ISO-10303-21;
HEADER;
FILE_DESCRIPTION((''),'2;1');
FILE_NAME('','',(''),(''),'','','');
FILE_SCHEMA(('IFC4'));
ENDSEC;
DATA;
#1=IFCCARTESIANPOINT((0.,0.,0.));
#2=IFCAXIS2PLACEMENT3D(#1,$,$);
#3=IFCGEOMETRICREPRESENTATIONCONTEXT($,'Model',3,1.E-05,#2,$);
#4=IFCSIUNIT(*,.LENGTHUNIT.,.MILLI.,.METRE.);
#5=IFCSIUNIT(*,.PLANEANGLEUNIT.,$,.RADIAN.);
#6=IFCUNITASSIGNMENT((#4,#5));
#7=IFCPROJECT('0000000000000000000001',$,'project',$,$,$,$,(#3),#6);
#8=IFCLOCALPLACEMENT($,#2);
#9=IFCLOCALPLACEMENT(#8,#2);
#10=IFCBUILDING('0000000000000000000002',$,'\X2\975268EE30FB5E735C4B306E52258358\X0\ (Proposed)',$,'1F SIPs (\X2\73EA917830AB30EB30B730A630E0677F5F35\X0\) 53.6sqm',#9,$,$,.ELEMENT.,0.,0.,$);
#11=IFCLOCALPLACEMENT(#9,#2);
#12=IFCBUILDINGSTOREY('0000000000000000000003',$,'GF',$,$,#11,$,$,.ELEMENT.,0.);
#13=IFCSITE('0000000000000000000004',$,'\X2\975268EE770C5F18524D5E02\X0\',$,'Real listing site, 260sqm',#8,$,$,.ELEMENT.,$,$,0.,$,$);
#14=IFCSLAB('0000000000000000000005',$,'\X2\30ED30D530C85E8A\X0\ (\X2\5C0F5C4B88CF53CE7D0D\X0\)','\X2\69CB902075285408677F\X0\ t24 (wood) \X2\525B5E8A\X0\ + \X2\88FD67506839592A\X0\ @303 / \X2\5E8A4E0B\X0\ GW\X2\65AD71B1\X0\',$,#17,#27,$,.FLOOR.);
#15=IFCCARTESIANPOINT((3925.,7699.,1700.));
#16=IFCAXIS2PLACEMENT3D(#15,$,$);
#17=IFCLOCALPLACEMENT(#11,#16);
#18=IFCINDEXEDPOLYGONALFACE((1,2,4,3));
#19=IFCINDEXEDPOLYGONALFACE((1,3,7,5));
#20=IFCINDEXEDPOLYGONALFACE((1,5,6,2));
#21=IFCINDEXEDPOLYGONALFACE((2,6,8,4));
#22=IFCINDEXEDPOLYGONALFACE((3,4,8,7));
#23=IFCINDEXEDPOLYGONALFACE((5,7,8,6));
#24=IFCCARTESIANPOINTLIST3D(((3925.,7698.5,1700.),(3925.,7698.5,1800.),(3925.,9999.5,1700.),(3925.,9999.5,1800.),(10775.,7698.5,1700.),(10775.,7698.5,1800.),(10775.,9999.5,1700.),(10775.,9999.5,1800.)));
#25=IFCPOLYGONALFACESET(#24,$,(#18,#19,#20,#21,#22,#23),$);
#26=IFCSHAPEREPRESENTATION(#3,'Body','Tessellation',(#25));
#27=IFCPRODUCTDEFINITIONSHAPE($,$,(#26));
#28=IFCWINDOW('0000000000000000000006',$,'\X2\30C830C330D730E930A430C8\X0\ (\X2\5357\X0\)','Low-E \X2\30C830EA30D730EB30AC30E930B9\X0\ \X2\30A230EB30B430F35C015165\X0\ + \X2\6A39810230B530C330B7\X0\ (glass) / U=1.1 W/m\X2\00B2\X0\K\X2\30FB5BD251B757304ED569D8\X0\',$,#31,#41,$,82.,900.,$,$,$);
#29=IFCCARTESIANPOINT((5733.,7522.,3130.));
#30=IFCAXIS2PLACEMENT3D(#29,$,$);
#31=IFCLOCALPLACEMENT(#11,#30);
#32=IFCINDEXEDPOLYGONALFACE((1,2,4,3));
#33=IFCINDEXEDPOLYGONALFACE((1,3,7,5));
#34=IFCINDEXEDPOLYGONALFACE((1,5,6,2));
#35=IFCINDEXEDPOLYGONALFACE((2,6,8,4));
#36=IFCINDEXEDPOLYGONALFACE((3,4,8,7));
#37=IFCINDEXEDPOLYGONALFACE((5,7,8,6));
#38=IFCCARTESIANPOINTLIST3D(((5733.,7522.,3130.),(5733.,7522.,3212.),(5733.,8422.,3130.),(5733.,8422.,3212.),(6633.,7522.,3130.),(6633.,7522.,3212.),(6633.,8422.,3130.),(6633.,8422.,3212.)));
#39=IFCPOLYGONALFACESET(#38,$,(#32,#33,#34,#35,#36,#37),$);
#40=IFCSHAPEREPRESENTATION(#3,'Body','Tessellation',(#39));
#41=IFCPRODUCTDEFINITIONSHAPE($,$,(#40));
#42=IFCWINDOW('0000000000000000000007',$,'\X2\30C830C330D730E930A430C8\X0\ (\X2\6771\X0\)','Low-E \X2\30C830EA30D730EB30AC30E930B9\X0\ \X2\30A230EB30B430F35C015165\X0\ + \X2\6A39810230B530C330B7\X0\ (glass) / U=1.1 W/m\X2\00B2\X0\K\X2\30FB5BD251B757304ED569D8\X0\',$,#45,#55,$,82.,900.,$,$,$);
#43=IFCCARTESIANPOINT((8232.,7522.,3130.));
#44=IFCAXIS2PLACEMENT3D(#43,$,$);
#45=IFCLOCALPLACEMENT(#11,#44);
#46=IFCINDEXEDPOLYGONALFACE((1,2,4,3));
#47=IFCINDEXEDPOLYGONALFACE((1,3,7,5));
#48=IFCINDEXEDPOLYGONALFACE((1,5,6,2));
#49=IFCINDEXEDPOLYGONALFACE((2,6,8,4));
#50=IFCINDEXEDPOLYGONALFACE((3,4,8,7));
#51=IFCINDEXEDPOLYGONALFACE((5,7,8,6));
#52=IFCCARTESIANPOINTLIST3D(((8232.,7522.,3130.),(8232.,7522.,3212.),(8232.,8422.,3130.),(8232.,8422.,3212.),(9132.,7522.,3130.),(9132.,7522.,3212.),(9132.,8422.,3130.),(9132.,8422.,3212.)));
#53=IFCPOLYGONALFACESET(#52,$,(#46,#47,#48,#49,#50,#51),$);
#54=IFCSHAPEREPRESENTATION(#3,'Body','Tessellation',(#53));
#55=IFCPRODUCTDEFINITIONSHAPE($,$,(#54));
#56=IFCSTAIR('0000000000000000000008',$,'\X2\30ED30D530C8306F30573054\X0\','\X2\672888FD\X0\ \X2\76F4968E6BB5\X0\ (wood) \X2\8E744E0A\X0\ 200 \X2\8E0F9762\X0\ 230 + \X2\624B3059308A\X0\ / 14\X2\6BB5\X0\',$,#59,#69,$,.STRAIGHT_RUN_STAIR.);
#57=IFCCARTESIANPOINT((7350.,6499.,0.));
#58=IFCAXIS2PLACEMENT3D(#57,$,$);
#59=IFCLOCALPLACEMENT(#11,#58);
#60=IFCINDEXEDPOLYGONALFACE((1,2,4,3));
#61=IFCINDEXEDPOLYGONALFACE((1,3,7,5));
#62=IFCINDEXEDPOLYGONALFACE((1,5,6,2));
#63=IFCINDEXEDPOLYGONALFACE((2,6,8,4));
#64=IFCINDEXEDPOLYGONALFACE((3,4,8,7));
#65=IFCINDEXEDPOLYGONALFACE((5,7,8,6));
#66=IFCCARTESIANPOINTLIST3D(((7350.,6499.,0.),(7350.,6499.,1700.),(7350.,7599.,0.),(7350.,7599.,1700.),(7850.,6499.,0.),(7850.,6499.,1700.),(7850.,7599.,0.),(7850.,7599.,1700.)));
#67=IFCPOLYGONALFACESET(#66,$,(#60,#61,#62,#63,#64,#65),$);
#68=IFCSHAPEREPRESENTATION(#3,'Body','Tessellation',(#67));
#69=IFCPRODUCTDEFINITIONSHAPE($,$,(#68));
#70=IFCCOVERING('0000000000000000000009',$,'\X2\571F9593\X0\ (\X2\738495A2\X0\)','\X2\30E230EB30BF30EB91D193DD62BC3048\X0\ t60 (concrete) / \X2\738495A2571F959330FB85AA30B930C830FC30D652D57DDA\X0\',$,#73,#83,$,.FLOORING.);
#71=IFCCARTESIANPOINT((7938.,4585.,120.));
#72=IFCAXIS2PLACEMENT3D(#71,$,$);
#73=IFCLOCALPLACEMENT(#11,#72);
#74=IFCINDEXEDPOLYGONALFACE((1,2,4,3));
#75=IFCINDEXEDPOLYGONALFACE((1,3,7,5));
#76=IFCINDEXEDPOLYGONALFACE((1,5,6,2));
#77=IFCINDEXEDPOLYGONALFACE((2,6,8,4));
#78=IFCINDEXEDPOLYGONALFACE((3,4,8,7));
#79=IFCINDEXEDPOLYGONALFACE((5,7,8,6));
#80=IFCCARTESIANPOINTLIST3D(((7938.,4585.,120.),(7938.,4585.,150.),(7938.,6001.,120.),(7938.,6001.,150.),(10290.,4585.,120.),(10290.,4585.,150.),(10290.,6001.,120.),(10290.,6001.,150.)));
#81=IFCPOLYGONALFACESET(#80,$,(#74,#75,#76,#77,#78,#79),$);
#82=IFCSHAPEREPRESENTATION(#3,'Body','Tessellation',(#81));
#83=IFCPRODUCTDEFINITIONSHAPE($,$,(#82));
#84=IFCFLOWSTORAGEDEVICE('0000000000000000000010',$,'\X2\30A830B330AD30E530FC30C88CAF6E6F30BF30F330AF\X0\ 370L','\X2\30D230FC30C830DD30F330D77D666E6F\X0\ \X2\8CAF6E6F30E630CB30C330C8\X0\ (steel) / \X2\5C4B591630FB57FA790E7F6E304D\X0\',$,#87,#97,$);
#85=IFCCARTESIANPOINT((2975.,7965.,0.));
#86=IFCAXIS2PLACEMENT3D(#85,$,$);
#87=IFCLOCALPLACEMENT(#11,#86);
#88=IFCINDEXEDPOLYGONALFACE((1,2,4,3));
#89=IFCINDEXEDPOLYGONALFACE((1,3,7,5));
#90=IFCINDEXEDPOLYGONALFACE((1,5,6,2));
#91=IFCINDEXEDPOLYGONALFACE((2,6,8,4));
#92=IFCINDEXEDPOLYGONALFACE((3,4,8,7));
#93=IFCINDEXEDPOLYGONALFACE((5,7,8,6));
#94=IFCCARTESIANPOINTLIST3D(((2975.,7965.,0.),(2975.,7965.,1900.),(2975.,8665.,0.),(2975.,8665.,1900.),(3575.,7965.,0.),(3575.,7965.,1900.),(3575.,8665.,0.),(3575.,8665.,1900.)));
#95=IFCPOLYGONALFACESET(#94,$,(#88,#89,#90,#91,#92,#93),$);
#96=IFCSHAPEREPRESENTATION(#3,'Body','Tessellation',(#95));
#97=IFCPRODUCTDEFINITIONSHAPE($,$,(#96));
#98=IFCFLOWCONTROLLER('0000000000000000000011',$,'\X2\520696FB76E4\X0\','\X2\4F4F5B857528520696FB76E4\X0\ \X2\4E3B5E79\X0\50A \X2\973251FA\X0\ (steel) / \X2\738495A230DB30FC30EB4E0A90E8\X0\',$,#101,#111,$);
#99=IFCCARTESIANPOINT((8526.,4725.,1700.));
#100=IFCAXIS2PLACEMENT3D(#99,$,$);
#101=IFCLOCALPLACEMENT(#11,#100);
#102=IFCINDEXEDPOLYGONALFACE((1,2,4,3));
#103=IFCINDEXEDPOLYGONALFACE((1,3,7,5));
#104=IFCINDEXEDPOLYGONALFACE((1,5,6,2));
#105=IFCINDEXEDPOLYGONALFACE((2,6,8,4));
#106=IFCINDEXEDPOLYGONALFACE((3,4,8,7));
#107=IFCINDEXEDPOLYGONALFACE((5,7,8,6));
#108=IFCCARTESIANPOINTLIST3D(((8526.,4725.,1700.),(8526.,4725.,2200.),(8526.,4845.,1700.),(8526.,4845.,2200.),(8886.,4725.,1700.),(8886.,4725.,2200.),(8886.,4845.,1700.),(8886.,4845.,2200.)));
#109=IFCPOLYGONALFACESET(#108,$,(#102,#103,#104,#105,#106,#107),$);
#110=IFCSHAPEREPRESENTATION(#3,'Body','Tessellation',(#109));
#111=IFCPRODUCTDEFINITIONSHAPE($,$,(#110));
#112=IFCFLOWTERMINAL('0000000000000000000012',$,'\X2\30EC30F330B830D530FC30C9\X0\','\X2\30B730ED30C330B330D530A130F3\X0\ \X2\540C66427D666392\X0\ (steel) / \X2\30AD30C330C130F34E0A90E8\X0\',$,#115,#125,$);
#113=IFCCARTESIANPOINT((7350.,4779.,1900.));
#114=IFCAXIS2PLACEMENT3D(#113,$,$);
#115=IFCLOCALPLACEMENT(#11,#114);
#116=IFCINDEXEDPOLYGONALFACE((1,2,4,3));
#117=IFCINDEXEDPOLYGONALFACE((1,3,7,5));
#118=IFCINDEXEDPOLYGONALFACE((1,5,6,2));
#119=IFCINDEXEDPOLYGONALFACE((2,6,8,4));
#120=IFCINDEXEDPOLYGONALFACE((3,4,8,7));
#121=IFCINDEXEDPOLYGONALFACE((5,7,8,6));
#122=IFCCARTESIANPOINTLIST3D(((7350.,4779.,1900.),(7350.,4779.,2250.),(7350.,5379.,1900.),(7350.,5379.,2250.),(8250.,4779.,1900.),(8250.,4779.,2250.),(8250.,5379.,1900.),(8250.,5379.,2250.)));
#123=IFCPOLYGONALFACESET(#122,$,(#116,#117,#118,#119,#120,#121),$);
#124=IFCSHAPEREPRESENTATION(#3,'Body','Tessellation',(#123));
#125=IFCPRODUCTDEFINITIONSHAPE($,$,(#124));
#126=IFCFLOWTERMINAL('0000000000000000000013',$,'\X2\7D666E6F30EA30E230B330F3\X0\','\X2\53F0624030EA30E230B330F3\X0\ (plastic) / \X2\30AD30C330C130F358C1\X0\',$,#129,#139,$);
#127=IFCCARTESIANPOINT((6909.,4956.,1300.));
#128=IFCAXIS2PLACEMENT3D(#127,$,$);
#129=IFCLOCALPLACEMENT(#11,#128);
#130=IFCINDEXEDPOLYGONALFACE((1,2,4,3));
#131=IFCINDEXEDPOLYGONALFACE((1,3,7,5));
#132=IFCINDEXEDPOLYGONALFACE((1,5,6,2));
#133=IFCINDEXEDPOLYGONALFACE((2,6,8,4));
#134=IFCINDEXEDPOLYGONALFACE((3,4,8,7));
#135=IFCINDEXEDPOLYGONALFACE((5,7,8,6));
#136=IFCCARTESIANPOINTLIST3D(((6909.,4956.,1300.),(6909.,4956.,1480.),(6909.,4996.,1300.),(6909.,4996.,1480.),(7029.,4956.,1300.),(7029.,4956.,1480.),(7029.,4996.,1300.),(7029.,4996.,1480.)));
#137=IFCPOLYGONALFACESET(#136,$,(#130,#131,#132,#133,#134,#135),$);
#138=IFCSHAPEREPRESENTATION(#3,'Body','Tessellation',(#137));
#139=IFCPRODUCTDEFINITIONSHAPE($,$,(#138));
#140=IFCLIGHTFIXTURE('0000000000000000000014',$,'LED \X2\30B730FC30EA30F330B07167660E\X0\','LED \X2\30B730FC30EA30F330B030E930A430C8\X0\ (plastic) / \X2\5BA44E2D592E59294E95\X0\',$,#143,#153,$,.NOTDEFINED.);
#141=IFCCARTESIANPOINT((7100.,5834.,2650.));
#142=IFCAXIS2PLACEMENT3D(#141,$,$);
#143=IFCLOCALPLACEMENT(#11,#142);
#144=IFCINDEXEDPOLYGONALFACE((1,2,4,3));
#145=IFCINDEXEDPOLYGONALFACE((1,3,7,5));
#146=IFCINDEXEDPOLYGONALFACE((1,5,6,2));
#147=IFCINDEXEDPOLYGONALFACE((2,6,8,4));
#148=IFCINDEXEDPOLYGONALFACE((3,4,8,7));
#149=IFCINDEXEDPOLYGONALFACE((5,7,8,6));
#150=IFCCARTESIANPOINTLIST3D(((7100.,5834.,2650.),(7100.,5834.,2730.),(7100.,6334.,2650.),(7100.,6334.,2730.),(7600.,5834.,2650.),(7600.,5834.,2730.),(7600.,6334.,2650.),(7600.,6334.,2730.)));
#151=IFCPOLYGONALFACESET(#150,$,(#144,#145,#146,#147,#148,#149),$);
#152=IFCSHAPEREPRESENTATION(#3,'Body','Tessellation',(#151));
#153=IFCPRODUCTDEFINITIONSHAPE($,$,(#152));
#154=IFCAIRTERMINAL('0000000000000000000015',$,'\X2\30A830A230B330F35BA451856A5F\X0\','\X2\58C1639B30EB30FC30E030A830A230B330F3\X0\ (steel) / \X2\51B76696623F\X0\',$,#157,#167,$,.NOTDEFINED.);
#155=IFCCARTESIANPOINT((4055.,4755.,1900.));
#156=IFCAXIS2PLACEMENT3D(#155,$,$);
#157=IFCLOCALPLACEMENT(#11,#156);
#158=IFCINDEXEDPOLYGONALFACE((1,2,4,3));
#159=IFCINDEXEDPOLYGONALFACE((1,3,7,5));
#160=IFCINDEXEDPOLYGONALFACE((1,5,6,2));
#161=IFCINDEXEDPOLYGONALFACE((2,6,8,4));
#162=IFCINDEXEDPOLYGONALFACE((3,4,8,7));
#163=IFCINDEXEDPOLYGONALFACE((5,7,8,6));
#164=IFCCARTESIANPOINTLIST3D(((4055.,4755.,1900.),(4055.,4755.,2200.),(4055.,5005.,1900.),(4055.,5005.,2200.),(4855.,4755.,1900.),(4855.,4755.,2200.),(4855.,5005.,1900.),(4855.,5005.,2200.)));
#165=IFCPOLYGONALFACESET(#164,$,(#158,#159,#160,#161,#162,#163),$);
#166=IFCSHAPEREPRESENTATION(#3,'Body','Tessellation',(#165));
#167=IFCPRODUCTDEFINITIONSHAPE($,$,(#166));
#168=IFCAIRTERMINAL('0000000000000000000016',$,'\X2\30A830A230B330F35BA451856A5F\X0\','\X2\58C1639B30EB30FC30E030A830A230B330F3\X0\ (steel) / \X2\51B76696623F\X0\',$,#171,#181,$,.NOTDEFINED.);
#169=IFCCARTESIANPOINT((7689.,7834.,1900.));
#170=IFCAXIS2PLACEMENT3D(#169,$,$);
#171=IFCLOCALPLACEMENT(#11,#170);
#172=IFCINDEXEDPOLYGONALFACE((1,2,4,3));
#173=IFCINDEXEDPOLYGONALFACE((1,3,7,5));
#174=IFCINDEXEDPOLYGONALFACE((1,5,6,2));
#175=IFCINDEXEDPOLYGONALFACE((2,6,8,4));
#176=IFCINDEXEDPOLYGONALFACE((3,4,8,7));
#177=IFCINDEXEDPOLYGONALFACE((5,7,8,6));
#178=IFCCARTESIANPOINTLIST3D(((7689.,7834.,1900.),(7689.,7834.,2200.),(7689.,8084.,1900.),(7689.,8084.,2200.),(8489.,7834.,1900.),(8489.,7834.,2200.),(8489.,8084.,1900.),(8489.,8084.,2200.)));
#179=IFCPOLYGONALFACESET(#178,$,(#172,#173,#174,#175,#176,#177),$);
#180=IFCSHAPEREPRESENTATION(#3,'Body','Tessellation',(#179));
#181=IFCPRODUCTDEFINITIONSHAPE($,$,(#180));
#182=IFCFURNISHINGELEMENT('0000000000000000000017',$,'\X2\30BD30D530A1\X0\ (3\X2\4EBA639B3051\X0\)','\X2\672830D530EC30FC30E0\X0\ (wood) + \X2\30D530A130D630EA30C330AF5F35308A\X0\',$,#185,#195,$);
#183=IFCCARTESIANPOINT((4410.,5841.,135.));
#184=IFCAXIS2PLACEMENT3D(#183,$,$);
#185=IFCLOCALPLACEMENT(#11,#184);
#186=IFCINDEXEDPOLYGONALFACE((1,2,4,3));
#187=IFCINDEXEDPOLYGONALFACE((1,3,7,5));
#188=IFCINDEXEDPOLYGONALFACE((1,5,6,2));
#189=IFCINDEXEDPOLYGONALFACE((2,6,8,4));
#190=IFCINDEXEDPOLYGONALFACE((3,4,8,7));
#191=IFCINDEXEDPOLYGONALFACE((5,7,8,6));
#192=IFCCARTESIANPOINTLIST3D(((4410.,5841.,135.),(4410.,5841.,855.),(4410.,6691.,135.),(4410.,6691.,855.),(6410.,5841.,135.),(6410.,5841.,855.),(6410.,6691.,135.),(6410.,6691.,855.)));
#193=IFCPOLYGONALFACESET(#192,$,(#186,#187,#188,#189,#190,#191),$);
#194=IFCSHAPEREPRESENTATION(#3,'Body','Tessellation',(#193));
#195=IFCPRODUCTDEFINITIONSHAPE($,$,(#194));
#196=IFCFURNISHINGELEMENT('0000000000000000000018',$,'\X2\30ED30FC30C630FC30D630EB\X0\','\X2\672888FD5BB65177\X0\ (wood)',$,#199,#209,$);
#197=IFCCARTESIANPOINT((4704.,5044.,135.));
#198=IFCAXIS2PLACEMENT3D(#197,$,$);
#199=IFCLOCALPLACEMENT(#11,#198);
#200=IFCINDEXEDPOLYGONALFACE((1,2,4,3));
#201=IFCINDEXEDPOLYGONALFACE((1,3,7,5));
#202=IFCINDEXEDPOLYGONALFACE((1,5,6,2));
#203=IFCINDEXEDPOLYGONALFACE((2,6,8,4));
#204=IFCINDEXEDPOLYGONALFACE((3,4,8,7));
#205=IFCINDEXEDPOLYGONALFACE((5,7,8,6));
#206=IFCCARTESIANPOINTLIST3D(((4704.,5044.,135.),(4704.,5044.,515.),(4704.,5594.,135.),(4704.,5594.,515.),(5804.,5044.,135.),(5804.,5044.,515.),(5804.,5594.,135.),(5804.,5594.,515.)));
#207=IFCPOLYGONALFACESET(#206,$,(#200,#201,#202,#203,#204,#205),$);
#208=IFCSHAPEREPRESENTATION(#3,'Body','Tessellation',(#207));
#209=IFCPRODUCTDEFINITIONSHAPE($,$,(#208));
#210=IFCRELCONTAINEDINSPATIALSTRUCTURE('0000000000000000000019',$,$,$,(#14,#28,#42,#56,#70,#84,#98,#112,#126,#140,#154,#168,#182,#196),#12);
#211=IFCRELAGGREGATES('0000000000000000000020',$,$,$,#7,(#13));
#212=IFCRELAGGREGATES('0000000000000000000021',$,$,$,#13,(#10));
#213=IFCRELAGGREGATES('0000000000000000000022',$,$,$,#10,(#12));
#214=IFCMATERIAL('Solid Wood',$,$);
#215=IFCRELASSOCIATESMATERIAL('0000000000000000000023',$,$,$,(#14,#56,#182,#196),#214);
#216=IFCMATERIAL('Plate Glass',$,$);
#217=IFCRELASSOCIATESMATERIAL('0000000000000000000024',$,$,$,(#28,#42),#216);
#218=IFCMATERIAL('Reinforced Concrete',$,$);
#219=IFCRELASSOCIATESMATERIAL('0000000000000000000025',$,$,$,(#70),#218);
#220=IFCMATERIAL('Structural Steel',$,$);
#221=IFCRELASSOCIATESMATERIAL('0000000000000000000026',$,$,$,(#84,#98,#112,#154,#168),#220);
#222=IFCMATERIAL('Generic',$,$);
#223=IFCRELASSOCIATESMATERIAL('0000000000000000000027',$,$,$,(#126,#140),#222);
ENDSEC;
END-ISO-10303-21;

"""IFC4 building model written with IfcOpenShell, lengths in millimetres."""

from ifc_helpers import new_model, si_unit, frame, frame_2d, origin, place, context, project, spatial, rectangle, extrude, material, element, save


model = new_model("IFC4")

# Units and contexts
model_context = context("Model", 3, precision=1e-05, world=origin())
ifc_project = project(units=[si_unit("LENGTHUNIT", "METRE", prefix="MILLI"), si_unit("PLANEANGLEUNIT", "RADIAN")], contexts=[model_context])

# Site, building, storey
site_placement = place(None, origin())
site = spatial("IfcSite", under=ifc_project, at=site_placement, Name="青森県弘前市", ObjectType="Real listing site, 260sqm", CompositionType="ELEMENT", RefElevation=0.0)
building_placement = place(site_placement, origin())
building = spatial("IfcBuilding", under=site, at=building_placement, Name="青森・平屋の別荘 (Proposed)", ObjectType="1F SIPs (珪酸カルシウム板張) 53.6sqm", CompositionType="ELEMENT", ElevationOfRefHeight=0.0, ElevationOfTerrain=0.0)
storey_placement = place(building_placement, origin())
storey = spatial("IfcBuildingStorey", under=building, at=storey_placement, Name="GF", CompositionType="ELEMENT", Elevation=0.0)

# Shared definitions
ifc_material_1 = material(Name="Solid Wood")

# Slab
slab_placement = place(storey_placement, frame((3925.0, 7699.0, 1700.0)))
element("IfcSlab", 1, at=slab_placement, inside=storey, material=ifc_material_1, Name="ロフト床 (小屋裏収納)", Description="構造用合板 t24 (wood) 剛床 + 製材根太 @303 / 床下 GW断熱", PredefinedType="FLOOR", context=model_context, shape_type="SweptSolid", body=[
    extrude(rectangle(XDim=6850.0, YDim=2301.0, at=frame_2d((3425.0, 1150.0))), frame((3925.0, 7699.0, 1700.0)), (0.0, 0.0, 1.0), 100.0),
])

# Windows
ifc_material_2 = material(Name="Plate Glass")
window_1_placement = place(storey_placement, frame((5733.0, 7522.0, 3130.0)))
element("IfcWindow", 2, at=window_1_placement, inside=storey, material=ifc_material_2, Name="トップライト (南)", Description="Low-E トリプルガラス アルゴン封入 + 樹脂サッシ (glass) / U=1.1 W/m²K・寒冷地仕様", OverallHeight=82.0, OverallWidth=900.0, context=model_context, shape_type="SweptSolid", body=[
    extrude(rectangle(XDim=900.0, YDim=900.0, at=frame_2d((450.0, 450.0))), frame((5733.0, 7522.0, 3130.0)), (0.0, 0.0, 1.0), 82.0),
])
window_2_placement = place(storey_placement, frame((8232.0, 7522.0, 3130.0)))
element("IfcWindow", 3, at=window_2_placement, inside=storey, material=ifc_material_2, Name="トップライト (東)", Description="Low-E トリプルガラス アルゴン封入 + 樹脂サッシ (glass) / U=1.1 W/m²K・寒冷地仕様", OverallHeight=82.0, OverallWidth=900.0, context=model_context, shape_type="SweptSolid", body=[
    extrude(rectangle(XDim=900.0, YDim=900.0, at=frame_2d((450.0, 450.0))), frame((8232.0, 7522.0, 3130.0)), (0.0, 0.0, 1.0), 82.0),
])

# Stair
stair_placement = place(storey_placement, frame((7350.0, 6499.0, 0.0)))
element("IfcStair", 4, at=stair_placement, inside=storey, material=ifc_material_1, Name="ロフトはしご", Description="木製 直階段 (wood) 蹴上 200 踏面 230 + 手すり / 14段", PredefinedType="STRAIGHT_RUN_STAIR", context=model_context, shape_type="SweptSolid", body=[
    extrude(rectangle(XDim=500.0, YDim=1100.0, at=frame_2d((250.0, 550.0))), frame((7350.0, 6499.0, 0.0)), (0.0, 0.0, 1.0), 1700.0),
])

# Covering
ifc_material_3 = material(Name="Reinforced Concrete")
covering_placement = place(storey_placement, frame((7938.0, 4585.0, 120.0)))
element("IfcCovering", 5, at=covering_placement, inside=storey, material=ifc_material_3, Name="土間 (玄関)", Description="モルタル金鏝押え t60 (concrete) / 玄関土間・薪ストーブ動線", PredefinedType="FLOORING", context=model_context, shape_type="SweptSolid", body=[
    extrude(rectangle(XDim=2352.0, YDim=1416.0, at=frame_2d((1176.0, 708.0))), frame((7938.0, 4585.0, 120.0)), (0.0, 0.0, 1.0), 30.0),
])

# Flow storage device
ifc_material_4 = material(Name="Structural Steel")
flow_storage_device_placement = place(storey_placement, frame((2975.0, 7965.0, 0.0)))
element("IfcFlowStorageDevice", 6, at=flow_storage_device_placement, inside=storey, material=ifc_material_4, Name="エコキュート貯湯タンク 370L", Description="ヒートポンプ給湯 貯湯ユニット (steel) / 屋外・基礎置き", context=model_context, shape_type="SweptSolid", body=[
    extrude(rectangle(XDim=600.0, YDim=700.0, at=frame_2d((300.0, 350.0))), frame((2975.0, 7965.0, 0.0)), (0.0, 0.0, 1.0), 1900.0),
])

# Flow controller
flow_controller_placement = place(storey_placement, frame((8526.0, 4725.0, 1700.0)))
element("IfcFlowController", 7, at=flow_controller_placement, inside=storey, material=ifc_material_4, Name="分電盤", Description="住宅用分電盤 主幹50A 露出 (steel) / 玄関ホール上部", context=model_context, shape_type="SweptSolid", body=[
    extrude(rectangle(XDim=360.0, YDim=120.0, at=frame_2d((180.0, 60.0))), frame((8526.0, 4725.0, 1700.0)), (0.0, 0.0, 1.0), 500.0),
])

# Flow terminals
flow_terminal_1_placement = place(storey_placement, frame((7350.0, 4779.0, 1900.0)))
element("IfcFlowTerminal", 8, at=flow_terminal_1_placement, inside=storey, material=ifc_material_4, Name="レンジフード", Description="シロッコファン 同時給排 (steel) / キッチン上部", context=model_context, shape_type="SweptSolid", body=[
    extrude(rectangle(XDim=900.0, YDim=600.0, at=frame_2d((450.0, 300.0))), frame((7350.0, 4779.0, 1900.0)), (0.0, 0.0, 1.0), 350.0),
])
ifc_material_5 = material(Name="Generic")
flow_terminal_2_placement = place(storey_placement, frame((6909.0, 4956.0, 1300.0)))
element("IfcFlowTerminal", 9, at=flow_terminal_2_placement, inside=storey, material=ifc_material_5, Name="給湯リモコン", Description="台所リモコン (plastic) / キッチン壁", context=model_context, shape_type="SweptSolid", body=[
    extrude(rectangle(XDim=120.0, YDim=40.0, at=frame_2d((60.0, 20.0))), frame((6909.0, 4956.0, 1300.0)), (0.0, 0.0, 1.0), 180.0),
])

# Light fixture
light_fixture_placement = place(storey_placement, frame((7100.0, 5834.0, 2650.0)))
element("IfcLightFixture", 10, at=light_fixture_placement, inside=storey, material=ifc_material_5, Name="LED シーリング照明", Description="LED シーリングライト (plastic) / 室中央天井", PredefinedType="NOTDEFINED", context=model_context, shape_type="SweptSolid", body=[
    extrude(rectangle(XDim=500.0, YDim=500.0, at=frame_2d((250.0, 250.0))), frame((7100.0, 5834.0, 2650.0)), (0.0, 0.0, 1.0), 80.0),
])

# Air terminals
air_terminal_1_placement = place(storey_placement, frame((4055.0, 4755.0, 1900.0)))
element("IfcAirTerminal", 11, at=air_terminal_1_placement, inside=storey, material=ifc_material_4, Name="エアコン室内機", Description="壁掛ルームエアコン (steel) / 冷暖房", PredefinedType="NOTDEFINED", context=model_context, shape_type="SweptSolid", body=[
    extrude(rectangle(XDim=800.0, YDim=250.0, at=frame_2d((400.0, 125.0))), frame((4055.0, 4755.0, 1900.0)), (0.0, 0.0, 1.0), 300.0),
])
air_terminal_2_placement = place(storey_placement, frame((7689.0, 7834.0, 1900.0)))
element("IfcAirTerminal", 12, at=air_terminal_2_placement, inside=storey, material=ifc_material_4, Name="エアコン室内機", Description="壁掛ルームエアコン (steel) / 冷暖房", PredefinedType="NOTDEFINED", context=model_context, shape_type="SweptSolid", body=[
    extrude(rectangle(XDim=800.0, YDim=250.0, at=frame_2d((400.0, 125.0))), frame((7689.0, 7834.0, 1900.0)), (0.0, 0.0, 1.0), 300.0),
])

# Furnishing elements
furnishing_1_placement = place(storey_placement, frame((4410.0, 5841.0, 135.0)))
element("IfcFurnishingElement", 13, at=furnishing_1_placement, inside=storey, material=ifc_material_1, Name="ソファ (3人掛け)", Description="木フレーム (wood) + ファブリック張り", context=model_context, shape_type="SweptSolid", body=[
    extrude(rectangle(XDim=2000.0, YDim=850.0, at=frame_2d((1000.0, 425.0))), frame((4410.0, 5841.0, 135.0)), (0.0, 0.0, 1.0), 720.0),
])
furnishing_2_placement = place(storey_placement, frame((4704.0, 5044.0, 135.0)))
element("IfcFurnishingElement", 14, at=furnishing_2_placement, inside=storey, material=ifc_material_1, Name="ローテーブル", Description="木製家具 (wood)", context=model_context, shape_type="SweptSolid", body=[
    extrude(rectangle(XDim=1100.0, YDim=550.0, at=frame_2d((550.0, 275.0))), frame((4704.0, 5044.0, 135.0)), (0.0, 0.0, 1.0), 380.0),
])

save(model, "model.ifc")
